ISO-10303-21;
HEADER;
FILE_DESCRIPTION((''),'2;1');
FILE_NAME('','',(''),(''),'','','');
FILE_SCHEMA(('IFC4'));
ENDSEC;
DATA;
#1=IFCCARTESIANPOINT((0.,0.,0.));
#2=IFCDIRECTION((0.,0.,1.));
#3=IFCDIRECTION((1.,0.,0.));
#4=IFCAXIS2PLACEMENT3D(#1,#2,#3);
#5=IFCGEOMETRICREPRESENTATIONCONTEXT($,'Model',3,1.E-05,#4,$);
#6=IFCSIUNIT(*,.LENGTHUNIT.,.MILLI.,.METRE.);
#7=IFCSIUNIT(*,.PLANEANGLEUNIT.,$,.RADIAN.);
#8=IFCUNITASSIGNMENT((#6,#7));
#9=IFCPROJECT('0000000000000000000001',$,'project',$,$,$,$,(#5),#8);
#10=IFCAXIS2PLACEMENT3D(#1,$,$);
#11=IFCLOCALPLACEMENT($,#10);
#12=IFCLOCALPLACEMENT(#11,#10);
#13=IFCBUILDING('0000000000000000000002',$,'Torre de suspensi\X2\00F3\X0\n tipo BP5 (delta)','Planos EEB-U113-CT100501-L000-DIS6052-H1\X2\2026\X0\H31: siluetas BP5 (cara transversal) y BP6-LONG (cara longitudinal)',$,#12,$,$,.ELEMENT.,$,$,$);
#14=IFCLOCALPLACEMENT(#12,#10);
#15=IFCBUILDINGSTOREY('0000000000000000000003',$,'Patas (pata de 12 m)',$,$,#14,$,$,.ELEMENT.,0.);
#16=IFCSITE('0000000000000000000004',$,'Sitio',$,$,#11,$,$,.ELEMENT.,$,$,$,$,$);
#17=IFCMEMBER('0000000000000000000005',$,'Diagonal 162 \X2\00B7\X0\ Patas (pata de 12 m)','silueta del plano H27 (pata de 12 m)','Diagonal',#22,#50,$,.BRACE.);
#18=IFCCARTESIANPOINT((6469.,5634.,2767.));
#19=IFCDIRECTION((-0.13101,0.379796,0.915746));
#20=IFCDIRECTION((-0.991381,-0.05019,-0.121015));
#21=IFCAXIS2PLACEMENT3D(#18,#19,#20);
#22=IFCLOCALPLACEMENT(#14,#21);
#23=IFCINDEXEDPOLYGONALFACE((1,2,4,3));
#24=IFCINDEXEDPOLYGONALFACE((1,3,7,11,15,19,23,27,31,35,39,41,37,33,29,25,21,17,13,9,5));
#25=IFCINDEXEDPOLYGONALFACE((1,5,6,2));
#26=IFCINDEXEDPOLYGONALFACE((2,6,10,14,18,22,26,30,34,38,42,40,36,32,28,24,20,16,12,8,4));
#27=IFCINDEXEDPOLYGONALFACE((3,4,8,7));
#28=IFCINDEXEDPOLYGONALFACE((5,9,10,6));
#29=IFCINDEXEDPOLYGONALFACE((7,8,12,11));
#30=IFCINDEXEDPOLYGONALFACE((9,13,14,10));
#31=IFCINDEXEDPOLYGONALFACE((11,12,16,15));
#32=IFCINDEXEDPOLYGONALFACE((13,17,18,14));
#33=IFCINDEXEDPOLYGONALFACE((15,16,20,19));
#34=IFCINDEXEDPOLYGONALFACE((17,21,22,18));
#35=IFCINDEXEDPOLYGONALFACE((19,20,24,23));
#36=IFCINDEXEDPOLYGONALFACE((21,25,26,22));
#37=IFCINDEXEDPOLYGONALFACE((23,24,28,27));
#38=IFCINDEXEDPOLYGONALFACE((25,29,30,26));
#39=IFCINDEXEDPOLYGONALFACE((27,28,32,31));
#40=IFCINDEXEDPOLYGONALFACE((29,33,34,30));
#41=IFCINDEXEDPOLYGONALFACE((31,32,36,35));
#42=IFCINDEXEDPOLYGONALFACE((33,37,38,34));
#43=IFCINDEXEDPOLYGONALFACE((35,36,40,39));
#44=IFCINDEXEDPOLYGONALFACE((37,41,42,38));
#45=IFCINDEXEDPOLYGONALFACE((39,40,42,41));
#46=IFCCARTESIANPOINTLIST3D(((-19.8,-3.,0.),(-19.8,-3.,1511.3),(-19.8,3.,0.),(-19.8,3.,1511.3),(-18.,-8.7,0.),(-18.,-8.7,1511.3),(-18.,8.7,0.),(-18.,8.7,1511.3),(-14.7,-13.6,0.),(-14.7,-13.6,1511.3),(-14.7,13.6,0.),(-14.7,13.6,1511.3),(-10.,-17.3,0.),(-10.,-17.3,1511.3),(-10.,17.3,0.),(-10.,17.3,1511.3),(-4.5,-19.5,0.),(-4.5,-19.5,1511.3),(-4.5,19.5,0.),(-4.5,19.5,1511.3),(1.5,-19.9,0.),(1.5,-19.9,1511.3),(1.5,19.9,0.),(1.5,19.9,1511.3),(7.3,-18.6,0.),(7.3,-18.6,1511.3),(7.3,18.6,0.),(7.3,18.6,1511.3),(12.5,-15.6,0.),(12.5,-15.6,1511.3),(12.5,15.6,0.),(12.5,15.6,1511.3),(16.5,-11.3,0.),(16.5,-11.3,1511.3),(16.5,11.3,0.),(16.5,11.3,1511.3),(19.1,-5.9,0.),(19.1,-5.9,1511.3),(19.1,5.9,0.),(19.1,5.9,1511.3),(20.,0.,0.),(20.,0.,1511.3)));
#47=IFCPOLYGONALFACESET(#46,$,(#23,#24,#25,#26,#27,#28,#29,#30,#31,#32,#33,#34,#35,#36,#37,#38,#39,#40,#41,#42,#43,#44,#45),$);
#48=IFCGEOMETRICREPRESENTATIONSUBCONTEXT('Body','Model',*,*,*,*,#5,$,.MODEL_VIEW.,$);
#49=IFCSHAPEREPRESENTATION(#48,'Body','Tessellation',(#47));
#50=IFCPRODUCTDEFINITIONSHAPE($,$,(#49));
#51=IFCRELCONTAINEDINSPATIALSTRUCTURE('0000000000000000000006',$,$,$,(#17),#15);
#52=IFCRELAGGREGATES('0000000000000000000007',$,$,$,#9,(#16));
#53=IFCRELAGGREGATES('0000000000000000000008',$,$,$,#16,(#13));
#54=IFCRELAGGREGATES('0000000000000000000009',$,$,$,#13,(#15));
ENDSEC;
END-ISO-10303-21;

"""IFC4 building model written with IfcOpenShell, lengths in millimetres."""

from ifc_helpers import new_model, si_unit, frame, origin, origin_with_axes, place, context, subcontext, project, spatial, circle, extrude, element, save


model = new_model("IFC4")

# Units and contexts
model_context = context("Model", 3, precision=1e-05, world=origin_with_axes())
body_context = subcontext(model_context, "Body", "Model", "MODEL_VIEW")
ifc_project = project(units=[si_unit("LENGTHUNIT", "METRE", prefix="MILLI"), si_unit("PLANEANGLEUNIT", "RADIAN")], contexts=[model_context])

# Site, building, storey
site_placement = place(None, origin())
site = spatial("IfcSite", under=ifc_project, at=site_placement, Name="Sitio", CompositionType="ELEMENT")
building_placement = place(site_placement, origin())
building = spatial("IfcBuilding", under=site, at=building_placement, Name="Torre de suspensión tipo BP5 (delta)", Description="Planos EEB-U113-CT100501-L000-DIS6052-H1…H31: siluetas BP5 (cara transversal) y BP6-LONG (cara longitudinal)", CompositionType="ELEMENT")
storey_placement = place(building_placement, origin())
storey = spatial("IfcBuildingStorey", under=building, at=storey_placement, Name="Patas (pata de 12 m)", CompositionType="ELEMENT", Elevation=0.0)

# Member
member_1_placement = place(storey_placement, frame((6469.0, 5634.0, 2767.0), z_axis=(-0.13101, 0.379796, 0.915746), x_axis=(-0.991381, -0.05019, -0.121015)))
element("IfcMember", 1, at=member_1_placement, inside=storey, Name="Diagonal 162 · Patas (pata de 12 m)", Description="silueta del plano H27 (pata de 12 m)", ObjectType="Diagonal", PredefinedType="BRACE", context=body_context, shape_type="SweptSolid", body=[
    extrude(circle(Radius=20.0), None, (0.0, 0.0, 1.0), 1511.3),
])

save(model, "model.ifc")
